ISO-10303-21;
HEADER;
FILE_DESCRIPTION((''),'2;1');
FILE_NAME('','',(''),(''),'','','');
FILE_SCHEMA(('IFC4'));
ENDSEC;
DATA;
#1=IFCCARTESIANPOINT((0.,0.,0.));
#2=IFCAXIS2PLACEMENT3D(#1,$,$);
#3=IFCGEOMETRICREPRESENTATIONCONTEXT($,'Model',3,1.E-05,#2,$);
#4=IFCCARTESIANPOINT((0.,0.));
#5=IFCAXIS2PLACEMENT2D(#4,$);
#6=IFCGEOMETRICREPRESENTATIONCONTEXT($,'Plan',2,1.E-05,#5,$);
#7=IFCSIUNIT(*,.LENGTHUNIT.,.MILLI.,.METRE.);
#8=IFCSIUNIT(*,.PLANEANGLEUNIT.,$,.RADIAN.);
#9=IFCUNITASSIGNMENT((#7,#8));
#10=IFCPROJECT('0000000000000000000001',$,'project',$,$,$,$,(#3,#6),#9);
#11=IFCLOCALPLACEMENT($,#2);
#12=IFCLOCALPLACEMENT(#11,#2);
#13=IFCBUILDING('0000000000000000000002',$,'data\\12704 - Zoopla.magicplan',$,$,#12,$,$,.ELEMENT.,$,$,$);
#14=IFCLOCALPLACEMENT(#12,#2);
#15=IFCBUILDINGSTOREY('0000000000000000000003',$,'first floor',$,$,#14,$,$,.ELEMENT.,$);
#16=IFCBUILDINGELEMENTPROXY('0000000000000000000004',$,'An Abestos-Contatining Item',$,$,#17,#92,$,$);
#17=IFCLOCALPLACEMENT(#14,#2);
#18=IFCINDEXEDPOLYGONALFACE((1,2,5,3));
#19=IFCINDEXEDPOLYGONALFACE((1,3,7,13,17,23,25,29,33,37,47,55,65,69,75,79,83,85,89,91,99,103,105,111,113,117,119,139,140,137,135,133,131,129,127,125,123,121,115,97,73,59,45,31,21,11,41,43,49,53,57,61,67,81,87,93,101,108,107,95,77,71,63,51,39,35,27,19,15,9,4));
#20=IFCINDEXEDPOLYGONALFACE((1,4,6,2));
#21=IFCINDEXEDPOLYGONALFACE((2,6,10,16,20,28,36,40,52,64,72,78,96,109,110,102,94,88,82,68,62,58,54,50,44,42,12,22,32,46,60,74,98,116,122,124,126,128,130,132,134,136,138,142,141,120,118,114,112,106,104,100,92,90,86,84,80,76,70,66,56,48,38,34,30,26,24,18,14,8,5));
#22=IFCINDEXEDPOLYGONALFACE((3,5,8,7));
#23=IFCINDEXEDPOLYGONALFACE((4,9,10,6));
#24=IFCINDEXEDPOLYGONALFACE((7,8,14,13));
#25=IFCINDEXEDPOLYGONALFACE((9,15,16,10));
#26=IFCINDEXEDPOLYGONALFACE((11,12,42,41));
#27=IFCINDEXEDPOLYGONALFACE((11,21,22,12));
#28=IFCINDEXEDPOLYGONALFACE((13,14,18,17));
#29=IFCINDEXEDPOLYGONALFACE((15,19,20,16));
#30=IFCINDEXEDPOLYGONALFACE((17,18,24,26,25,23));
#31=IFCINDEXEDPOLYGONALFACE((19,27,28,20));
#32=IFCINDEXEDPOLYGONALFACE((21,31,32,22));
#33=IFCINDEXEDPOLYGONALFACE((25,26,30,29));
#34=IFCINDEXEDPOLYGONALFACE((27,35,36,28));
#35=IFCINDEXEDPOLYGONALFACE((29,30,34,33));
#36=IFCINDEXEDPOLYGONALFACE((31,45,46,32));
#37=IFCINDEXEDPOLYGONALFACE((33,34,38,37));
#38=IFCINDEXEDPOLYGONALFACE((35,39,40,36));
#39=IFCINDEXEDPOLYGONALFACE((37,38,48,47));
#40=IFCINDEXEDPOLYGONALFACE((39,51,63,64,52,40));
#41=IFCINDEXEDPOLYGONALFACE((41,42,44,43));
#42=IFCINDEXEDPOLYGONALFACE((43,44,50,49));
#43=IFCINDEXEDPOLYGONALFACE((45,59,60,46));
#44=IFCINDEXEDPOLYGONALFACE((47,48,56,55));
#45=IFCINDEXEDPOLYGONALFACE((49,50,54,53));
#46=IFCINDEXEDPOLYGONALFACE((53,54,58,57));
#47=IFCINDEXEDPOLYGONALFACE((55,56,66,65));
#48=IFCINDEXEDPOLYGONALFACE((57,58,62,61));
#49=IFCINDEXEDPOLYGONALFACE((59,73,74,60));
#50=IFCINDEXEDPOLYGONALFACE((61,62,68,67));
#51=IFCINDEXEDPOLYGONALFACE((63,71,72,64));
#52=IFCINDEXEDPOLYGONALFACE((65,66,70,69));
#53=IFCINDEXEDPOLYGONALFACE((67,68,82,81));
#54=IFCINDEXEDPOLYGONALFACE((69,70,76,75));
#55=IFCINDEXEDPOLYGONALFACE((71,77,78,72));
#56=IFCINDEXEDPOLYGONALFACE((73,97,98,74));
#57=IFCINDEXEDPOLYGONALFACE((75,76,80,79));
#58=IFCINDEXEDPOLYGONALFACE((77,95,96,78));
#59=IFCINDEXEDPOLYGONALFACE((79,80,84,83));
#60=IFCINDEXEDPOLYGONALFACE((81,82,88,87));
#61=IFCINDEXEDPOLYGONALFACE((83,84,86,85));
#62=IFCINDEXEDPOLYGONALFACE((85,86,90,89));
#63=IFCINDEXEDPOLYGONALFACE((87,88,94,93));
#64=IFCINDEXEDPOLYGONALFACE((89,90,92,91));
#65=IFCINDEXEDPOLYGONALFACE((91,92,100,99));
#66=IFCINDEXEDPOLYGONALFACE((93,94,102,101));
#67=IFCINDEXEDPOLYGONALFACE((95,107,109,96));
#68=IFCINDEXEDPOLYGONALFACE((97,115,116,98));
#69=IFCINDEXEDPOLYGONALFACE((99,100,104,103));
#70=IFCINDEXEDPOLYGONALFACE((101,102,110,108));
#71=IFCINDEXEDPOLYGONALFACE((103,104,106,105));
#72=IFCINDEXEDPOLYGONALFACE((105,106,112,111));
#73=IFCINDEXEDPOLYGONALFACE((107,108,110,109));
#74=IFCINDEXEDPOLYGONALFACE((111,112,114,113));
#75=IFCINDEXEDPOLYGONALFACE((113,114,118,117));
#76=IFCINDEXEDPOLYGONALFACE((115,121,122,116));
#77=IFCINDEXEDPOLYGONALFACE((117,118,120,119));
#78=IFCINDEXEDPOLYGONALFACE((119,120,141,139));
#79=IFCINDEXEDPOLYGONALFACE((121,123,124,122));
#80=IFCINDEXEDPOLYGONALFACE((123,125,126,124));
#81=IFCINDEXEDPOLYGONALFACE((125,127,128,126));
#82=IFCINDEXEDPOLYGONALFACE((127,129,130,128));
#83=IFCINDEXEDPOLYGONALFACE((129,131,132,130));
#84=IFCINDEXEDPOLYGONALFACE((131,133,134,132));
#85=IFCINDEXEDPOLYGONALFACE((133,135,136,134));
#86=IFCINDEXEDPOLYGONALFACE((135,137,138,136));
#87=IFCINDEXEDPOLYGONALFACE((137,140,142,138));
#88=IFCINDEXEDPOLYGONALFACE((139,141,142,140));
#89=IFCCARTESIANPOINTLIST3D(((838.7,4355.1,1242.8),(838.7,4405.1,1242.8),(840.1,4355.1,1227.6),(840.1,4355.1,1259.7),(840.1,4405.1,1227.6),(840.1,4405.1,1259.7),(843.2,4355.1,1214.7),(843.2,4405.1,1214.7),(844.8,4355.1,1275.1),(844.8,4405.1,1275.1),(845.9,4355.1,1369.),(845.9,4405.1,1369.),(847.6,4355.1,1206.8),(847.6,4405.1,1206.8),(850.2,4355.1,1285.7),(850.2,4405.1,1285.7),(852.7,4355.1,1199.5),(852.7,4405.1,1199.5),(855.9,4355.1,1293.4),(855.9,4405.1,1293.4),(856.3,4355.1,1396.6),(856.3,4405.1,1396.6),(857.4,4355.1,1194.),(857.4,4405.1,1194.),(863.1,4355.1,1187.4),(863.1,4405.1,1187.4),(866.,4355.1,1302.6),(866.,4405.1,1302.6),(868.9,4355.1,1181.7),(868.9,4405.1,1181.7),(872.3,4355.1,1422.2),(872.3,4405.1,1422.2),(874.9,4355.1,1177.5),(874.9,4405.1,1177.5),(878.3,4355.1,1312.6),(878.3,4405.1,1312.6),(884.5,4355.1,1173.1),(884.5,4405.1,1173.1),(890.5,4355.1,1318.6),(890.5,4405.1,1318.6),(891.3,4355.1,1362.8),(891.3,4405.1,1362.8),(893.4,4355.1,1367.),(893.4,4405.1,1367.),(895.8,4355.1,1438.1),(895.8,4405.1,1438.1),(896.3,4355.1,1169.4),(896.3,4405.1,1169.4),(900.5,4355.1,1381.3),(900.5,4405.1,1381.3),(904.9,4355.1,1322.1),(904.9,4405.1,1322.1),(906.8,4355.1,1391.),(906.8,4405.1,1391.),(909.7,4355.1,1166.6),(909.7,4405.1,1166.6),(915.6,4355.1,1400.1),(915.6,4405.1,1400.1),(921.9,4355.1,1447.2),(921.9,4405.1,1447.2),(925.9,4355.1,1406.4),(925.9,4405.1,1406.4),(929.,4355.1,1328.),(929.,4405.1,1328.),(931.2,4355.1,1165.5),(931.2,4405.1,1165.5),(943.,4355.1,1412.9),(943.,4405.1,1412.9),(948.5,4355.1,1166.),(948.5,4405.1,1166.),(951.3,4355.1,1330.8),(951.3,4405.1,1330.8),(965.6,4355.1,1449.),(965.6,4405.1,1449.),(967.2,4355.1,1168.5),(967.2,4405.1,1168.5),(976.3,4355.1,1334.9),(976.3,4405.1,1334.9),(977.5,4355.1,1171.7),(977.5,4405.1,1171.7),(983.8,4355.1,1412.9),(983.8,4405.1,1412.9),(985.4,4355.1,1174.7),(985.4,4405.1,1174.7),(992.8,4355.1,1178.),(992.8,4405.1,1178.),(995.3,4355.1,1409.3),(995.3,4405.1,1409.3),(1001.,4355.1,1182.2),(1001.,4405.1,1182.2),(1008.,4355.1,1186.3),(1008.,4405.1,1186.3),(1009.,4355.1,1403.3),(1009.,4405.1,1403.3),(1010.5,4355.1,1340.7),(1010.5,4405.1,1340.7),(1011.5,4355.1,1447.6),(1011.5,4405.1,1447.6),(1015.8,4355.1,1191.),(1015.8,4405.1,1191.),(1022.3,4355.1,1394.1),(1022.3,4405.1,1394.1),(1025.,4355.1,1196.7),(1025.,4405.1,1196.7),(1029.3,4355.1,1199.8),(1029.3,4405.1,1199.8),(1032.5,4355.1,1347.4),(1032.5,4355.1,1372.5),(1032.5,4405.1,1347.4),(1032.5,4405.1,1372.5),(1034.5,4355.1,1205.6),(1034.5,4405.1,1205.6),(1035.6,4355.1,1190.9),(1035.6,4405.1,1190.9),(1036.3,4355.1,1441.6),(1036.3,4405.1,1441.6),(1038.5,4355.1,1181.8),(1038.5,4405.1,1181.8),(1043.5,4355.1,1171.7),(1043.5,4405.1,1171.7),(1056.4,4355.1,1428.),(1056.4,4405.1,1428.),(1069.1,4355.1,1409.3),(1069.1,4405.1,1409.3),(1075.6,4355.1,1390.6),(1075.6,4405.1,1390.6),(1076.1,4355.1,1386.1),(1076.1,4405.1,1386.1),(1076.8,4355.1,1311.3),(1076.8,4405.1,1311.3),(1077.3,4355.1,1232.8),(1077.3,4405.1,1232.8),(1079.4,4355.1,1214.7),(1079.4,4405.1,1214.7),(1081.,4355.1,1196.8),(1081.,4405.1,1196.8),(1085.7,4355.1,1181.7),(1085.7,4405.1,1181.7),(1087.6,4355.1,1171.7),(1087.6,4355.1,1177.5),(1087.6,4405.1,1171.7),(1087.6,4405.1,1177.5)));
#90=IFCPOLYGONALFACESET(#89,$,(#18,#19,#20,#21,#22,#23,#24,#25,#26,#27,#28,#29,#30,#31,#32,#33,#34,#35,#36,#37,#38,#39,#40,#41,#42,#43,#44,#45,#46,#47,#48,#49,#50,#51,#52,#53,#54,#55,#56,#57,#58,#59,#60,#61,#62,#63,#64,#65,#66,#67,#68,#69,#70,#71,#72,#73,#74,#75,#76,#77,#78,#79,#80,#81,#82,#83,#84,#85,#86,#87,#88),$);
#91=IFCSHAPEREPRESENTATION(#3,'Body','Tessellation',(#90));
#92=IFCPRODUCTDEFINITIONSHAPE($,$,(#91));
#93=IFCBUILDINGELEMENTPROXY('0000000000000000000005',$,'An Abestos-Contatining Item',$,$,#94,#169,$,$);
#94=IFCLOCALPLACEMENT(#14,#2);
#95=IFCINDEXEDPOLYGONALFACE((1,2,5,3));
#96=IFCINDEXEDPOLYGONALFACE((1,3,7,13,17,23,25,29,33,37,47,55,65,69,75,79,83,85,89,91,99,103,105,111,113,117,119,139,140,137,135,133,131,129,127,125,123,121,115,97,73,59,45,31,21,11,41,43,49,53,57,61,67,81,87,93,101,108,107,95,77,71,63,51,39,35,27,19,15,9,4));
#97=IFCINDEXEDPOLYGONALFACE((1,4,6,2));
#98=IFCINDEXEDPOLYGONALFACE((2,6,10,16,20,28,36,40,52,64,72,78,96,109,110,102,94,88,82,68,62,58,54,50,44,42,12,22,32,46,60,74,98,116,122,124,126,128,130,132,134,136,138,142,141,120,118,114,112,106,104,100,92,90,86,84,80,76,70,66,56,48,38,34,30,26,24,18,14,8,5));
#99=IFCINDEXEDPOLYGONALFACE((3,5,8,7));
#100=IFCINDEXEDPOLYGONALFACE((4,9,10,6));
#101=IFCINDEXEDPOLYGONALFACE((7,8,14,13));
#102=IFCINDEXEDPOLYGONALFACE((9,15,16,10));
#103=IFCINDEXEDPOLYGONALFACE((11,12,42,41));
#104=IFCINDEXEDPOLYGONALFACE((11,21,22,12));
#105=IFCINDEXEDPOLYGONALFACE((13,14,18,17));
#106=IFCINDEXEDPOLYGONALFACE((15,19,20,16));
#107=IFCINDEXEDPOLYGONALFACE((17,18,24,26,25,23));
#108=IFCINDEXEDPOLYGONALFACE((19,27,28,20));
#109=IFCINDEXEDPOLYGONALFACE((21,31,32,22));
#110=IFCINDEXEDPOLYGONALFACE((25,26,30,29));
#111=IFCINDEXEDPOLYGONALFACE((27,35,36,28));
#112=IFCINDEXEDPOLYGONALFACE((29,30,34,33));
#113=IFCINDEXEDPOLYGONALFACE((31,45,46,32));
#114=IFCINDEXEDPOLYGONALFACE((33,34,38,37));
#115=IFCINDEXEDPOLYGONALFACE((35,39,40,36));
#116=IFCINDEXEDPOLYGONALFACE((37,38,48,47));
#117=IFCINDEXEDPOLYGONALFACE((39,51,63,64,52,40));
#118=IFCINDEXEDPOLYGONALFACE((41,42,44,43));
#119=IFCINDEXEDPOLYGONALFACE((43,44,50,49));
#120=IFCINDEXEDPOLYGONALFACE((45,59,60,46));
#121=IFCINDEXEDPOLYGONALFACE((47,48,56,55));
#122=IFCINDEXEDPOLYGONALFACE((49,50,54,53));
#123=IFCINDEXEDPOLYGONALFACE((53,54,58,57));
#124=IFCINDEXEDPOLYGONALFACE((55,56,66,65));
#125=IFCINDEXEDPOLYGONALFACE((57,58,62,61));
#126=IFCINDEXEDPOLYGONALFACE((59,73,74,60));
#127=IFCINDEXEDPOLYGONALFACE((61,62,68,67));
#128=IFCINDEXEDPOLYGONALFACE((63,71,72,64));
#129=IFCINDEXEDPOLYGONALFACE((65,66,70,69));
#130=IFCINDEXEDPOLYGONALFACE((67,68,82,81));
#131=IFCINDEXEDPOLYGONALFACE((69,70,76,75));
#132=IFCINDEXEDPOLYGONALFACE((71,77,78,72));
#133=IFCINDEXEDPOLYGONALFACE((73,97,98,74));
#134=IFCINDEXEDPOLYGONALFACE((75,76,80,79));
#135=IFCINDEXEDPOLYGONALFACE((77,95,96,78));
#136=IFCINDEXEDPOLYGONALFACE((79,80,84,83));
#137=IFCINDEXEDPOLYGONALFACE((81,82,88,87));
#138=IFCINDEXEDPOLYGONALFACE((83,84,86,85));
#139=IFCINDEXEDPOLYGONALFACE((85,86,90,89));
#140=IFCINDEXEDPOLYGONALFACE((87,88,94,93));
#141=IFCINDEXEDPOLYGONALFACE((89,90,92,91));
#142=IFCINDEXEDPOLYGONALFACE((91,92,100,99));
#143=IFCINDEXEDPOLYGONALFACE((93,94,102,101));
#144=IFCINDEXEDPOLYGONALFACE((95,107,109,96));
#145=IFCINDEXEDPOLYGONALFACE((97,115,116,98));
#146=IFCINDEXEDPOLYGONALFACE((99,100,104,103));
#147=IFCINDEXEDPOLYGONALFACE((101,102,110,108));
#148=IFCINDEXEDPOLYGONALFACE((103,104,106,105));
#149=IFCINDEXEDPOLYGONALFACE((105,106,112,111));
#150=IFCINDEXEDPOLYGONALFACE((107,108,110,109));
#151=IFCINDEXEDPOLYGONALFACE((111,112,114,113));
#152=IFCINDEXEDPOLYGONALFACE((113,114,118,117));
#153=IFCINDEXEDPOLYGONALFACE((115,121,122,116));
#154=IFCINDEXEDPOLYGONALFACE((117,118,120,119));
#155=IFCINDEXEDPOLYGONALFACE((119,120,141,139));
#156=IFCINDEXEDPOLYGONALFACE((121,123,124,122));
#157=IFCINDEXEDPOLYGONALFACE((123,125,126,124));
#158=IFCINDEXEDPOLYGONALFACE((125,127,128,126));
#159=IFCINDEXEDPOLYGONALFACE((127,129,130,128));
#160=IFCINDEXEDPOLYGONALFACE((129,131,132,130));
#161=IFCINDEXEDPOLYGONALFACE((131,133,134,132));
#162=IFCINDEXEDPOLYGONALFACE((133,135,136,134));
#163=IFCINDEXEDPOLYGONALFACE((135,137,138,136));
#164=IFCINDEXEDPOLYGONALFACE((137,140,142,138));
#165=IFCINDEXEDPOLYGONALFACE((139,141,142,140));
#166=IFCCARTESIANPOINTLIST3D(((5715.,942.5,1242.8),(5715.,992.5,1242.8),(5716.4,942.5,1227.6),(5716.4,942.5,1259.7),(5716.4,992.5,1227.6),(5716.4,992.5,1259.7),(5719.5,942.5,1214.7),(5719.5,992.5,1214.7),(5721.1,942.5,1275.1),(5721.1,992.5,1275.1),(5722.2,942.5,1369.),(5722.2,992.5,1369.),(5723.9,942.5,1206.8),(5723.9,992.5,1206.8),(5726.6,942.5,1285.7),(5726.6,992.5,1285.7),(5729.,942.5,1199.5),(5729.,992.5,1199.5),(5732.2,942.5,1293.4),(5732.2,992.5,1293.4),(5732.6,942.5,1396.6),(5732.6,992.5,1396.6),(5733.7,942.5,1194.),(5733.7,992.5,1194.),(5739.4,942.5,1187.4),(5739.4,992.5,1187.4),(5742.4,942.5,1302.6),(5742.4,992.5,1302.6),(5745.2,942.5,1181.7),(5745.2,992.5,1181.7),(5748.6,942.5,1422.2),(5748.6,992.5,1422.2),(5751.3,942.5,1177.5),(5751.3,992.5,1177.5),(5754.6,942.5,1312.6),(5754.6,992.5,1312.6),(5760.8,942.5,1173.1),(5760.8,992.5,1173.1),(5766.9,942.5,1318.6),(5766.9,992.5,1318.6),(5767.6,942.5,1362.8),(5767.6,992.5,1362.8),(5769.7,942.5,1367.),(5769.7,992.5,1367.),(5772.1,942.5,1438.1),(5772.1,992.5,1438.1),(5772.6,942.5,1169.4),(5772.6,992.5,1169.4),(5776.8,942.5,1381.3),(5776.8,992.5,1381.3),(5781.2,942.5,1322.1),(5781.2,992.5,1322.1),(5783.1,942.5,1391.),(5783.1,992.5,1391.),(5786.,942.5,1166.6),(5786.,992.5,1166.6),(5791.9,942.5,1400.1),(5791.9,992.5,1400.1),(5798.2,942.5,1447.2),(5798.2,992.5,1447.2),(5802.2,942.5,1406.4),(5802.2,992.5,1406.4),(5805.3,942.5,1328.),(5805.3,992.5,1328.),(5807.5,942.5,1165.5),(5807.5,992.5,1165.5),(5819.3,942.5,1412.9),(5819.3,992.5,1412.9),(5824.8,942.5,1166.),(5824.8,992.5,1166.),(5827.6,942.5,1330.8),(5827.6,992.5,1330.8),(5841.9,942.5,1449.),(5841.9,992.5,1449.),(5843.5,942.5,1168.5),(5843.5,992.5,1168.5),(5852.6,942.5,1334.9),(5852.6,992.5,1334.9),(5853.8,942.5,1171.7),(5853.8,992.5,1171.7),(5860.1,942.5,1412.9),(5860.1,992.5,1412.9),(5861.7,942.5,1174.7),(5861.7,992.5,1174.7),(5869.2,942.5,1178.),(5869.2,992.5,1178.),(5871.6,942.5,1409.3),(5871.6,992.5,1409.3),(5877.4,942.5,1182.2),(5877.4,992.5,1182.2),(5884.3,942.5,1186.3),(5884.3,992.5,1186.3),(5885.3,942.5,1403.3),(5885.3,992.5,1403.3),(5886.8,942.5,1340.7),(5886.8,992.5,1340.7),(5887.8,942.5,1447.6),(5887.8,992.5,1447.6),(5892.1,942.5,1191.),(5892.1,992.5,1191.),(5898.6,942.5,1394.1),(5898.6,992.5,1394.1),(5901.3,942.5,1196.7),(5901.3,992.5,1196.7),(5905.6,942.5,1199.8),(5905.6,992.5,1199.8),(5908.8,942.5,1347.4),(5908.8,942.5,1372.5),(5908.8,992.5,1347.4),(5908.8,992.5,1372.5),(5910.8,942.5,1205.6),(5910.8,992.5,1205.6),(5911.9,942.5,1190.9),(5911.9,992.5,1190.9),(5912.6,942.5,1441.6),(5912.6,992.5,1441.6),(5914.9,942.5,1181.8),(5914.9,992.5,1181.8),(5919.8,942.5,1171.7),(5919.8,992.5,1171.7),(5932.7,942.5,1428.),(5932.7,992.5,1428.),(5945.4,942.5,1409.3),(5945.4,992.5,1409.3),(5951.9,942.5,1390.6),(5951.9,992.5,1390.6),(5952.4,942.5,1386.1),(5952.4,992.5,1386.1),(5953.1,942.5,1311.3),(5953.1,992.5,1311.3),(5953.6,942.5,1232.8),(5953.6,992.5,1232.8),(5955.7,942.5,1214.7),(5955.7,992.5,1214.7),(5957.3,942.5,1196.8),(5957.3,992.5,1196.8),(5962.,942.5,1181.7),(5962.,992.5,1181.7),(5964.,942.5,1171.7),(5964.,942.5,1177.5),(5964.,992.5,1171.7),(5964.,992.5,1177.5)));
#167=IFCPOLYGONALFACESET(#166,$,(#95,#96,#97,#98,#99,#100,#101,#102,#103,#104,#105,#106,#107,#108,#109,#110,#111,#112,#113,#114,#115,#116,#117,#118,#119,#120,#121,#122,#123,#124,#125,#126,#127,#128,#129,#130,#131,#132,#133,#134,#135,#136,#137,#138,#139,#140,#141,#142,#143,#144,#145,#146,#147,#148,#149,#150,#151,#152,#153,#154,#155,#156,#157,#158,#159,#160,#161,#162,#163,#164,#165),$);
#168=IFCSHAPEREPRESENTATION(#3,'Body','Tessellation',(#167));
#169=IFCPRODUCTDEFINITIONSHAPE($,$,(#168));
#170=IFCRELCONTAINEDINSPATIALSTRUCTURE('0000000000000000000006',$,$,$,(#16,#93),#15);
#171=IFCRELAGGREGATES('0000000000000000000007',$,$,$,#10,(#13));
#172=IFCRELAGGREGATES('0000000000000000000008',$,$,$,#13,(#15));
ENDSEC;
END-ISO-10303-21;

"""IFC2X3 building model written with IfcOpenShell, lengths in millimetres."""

from ifc_helpers import new_model, si_unit, frame, origin, origin_2d, place, context, project, spatial, polyline, outline, extrude, element, save


model = new_model("IFC2X3")

# Units and contexts
model_context = context("Model", 3, precision=1e-05, world=origin())
plan_context = context("Plan", 2, precision=1e-05, world=origin_2d())
ifc_project = project(units=[si_unit("LENGTHUNIT", "METRE", prefix="MILLI"), si_unit("PLANEANGLEUNIT", "RADIAN")], contexts=[model_context, plan_context])

# Building, storey
placement_1 = place(None, origin())
building_placement = place(placement_1, origin())
building = spatial("IfcBuilding", under=ifc_project, at=building_placement, Name="data\\12704 - Zoopla.magicplan", CompositionType="ELEMENT")
storey_placement = place(building_placement, origin())
storey = spatial("IfcBuildingStorey", under=building, at=storey_placement, Name="first floor", CompositionType="ELEMENT")

# Building element proxies
placement_2 = place(None, frame((3984.0, 1316.8, 0.0)))
proxy_1_placement = place(placement_2, frame((-3146.3, 3088.3, 1165.0)))
element("IfcBuildingElementProxy", 1, at=proxy_1_placement, inside=storey, Name="An Abestos-Contatining Item", context=model_context, shape_type="SurfaceModel", body=[
    extrude(outline(polyline([(239.2, 0.0, 146.3), (239.7, 0.0, 67.8), (241.8, 0.0, 49.7), (243.3, 0.0, 31.9), (248.1, 0.0, 16.7), (250.0, 0.0, 12.5), (250.0, 0.0, 6.7), (205.8, 0.0, 6.7), (200.9, 0.0, 16.8), (197.9, 0.0, 25.9), (196.9, 0.0, 40.6), (191.6, 0.0, 34.8), (187.3, 0.0, 31.7), (178.2, 0.0, 26.0), (170.3, 0.0, 21.3), (163.4, 0.0, 17.2), (155.2, 0.0, 13.0), (147.8, 0.0, 9.7), (139.9, 0.0, 6.7), (129.5, 0.0, 3.5), (110.9, 0.0, 1.0), (93.6, 0.0, 0.5), (72.1, 0.0, 1.6), (58.6, 0.0, 4.4), (46.9, 0.0, 8.1), (37.3, 0.0, 12.5), (31.2, 0.0, 16.7), (25.4, 0.0, 22.4), (19.8, 0.0, 29.0), (15.1, 0.0, 34.5), (9.9, 0.0, 41.9), (5.5, 0.0, 49.7), (2.5, 0.0, 62.6), (1.0, 0.0, 77.8), (2.5, 0.0, 94.7), (7.2, 0.0, 110.1), (12.6, 0.0, 120.7), (18.2, 0.0, 128.4), (28.4, 0.0, 137.6), (40.7, 0.0, 147.6), (52.9, 0.0, 153.6), (67.3, 0.0, 157.1), (91.3, 0.0, 163.0), (113.7, 0.0, 165.8), (138.6, 0.0, 169.9), (172.9, 0.0, 175.7), (194.8, 0.0, 182.4), (194.8, 0.0, 207.5), (184.7, 0.0, 229.1), (171.3, 0.0, 238.3), (157.6, 0.0, 244.3), (146.2, 0.0, 247.9), (105.3, 0.0, 247.9), (88.3, 0.0, 241.4), (77.9, 0.0, 235.1), (69.1, 0.0, 226.0), (62.9, 0.0, 216.3), (55.7, 0.0, 202.0), (53.6, 0.0, 197.8), (8.2, 0.0, 204.0), (18.7, 0.0, 231.7), (34.6, 0.0, 257.2), (58.1, 0.0, 273.1), (84.2, 0.0, 282.2), (128.0, 0.0, 284.0), (173.9, 0.0, 282.6), (198.6, 0.0, 276.6), (218.8, 0.0, 263.1), (231.4, 0.0, 244.3), (238.0, 0.0, 225.6), (238.5, 0.0, 221.1)]), holes=[polyline([(193.0, 0.0, 144.2), (193.0, 0.0, 117.7), (190.5, 0.0, 97.8), (183.8, 0.0, 80.4), (174.2, 0.0, 64.5), (165.3, 0.0, 54.4), (152.5, 0.0, 47.3), (138.0, 0.0, 41.5), (124.6, 0.0, 37.8), (85.5, 0.0, 37.8), (75.0, 0.0, 41.4), (65.8, 0.0, 47.1), (57.8, 0.0, 55.4), (52.1, 0.0, 66.4), (49.5, 0.0, 74.4), (49.5, 0.0, 88.6), (55.3, 0.0, 100.7), (65.3, 0.0, 109.9), (81.0, 0.0, 119.8), (101.0, 0.0, 125.3), (119.9, 0.0, 128.5), (146.8, 0.0, 131.5), (165.0, 0.0, 134.9), (179.8, 0.0, 140.1), (193.0, 0.0, 144.2)])], kind="CURVE"), origin(), (0.0, -1.0, 0.0), 50.0),
])
placement_3 = place(None, frame((3984.0, 1316.8, 0.0)))
proxy_2_placement = place(placement_3, frame((1730.0, -324.3, 1165.0)))
element("IfcBuildingElementProxy", 2, at=proxy_2_placement, inside=storey, Name="An Abestos-Contatining Item", context=model_context, shape_type="SurfaceModel", body=[
    extrude(outline(polyline([(239.2, 0.0, 146.3), (239.7, 0.0, 67.8), (241.8, 0.0, 49.7), (243.3, 0.0, 31.9), (248.1, 0.0, 16.7), (250.0, 0.0, 12.5), (250.0, 0.0, 6.7), (205.8, 0.0, 6.7), (200.9, 0.0, 16.8), (197.9, 0.0, 25.9), (196.9, 0.0, 40.6), (191.6, 0.0, 34.8), (187.3, 0.0, 31.7), (178.2, 0.0, 26.0), (170.3, 0.0, 21.3), (163.4, 0.0, 17.2), (155.2, 0.0, 13.0), (147.8, 0.0, 9.7), (139.9, 0.0, 6.7), (129.5, 0.0, 3.5), (110.9, 0.0, 1.0), (93.6, 0.0, 0.5), (72.1, 0.0, 1.6), (58.6, 0.0, 4.4), (46.9, 0.0, 8.1), (37.3, 0.0, 12.5), (31.2, 0.0, 16.7), (25.4, 0.0, 22.4), (19.8, 0.0, 29.0), (15.1, 0.0, 34.5), (9.9, 0.0, 41.9), (5.5, 0.0, 49.7), (2.5, 0.0, 62.6), (1.0, 0.0, 77.8), (2.5, 0.0, 94.7), (7.2, 0.0, 110.1), (12.6, 0.0, 120.7), (18.2, 0.0, 128.4), (28.4, 0.0, 137.6), (40.7, 0.0, 147.6), (52.9, 0.0, 153.6), (67.3, 0.0, 157.1), (91.3, 0.0, 163.0), (113.7, 0.0, 165.8), (138.6, 0.0, 169.9), (172.9, 0.0, 175.7), (194.8, 0.0, 182.4), (194.8, 0.0, 207.5), (184.7, 0.0, 229.1), (171.3, 0.0, 238.3), (157.6, 0.0, 244.3), (146.2, 0.0, 247.9), (105.3, 0.0, 247.9), (88.3, 0.0, 241.4), (77.9, 0.0, 235.1), (69.1, 0.0, 226.0), (62.9, 0.0, 216.3), (55.7, 0.0, 202.0), (53.6, 0.0, 197.8), (8.2, 0.0, 204.0), (18.7, 0.0, 231.7), (34.6, 0.0, 257.2), (58.1, 0.0, 273.1), (84.2, 0.0, 282.2), (128.0, 0.0, 284.0), (173.9, 0.0, 282.6), (198.6, 0.0, 276.6), (218.8, 0.0, 263.1), (231.4, 0.0, 244.3), (238.0, 0.0, 225.6), (238.5, 0.0, 221.1)]), holes=[polyline([(193.0, 0.0, 144.2), (193.0, 0.0, 117.7), (190.5, 0.0, 97.8), (183.8, 0.0, 80.4), (174.2, 0.0, 64.5), (165.3, 0.0, 54.4), (152.5, 0.0, 47.3), (138.0, 0.0, 41.5), (124.6, 0.0, 37.8), (85.5, 0.0, 37.8), (75.0, 0.0, 41.4), (65.8, 0.0, 47.1), (57.8, 0.0, 55.4), (52.1, 0.0, 66.4), (49.5, 0.0, 74.4), (49.5, 0.0, 88.6), (55.3, 0.0, 100.7), (65.3, 0.0, 109.9), (81.0, 0.0, 119.8), (101.0, 0.0, 125.3), (119.9, 0.0, 128.5), (146.8, 0.0, 131.5), (165.0, 0.0, 134.9), (179.8, 0.0, 140.1), (193.0, 0.0, 144.2)])], kind="CURVE"), origin(), (0.0, -1.0, 0.0), 50.0),
])

save(model, "model.ifc")
